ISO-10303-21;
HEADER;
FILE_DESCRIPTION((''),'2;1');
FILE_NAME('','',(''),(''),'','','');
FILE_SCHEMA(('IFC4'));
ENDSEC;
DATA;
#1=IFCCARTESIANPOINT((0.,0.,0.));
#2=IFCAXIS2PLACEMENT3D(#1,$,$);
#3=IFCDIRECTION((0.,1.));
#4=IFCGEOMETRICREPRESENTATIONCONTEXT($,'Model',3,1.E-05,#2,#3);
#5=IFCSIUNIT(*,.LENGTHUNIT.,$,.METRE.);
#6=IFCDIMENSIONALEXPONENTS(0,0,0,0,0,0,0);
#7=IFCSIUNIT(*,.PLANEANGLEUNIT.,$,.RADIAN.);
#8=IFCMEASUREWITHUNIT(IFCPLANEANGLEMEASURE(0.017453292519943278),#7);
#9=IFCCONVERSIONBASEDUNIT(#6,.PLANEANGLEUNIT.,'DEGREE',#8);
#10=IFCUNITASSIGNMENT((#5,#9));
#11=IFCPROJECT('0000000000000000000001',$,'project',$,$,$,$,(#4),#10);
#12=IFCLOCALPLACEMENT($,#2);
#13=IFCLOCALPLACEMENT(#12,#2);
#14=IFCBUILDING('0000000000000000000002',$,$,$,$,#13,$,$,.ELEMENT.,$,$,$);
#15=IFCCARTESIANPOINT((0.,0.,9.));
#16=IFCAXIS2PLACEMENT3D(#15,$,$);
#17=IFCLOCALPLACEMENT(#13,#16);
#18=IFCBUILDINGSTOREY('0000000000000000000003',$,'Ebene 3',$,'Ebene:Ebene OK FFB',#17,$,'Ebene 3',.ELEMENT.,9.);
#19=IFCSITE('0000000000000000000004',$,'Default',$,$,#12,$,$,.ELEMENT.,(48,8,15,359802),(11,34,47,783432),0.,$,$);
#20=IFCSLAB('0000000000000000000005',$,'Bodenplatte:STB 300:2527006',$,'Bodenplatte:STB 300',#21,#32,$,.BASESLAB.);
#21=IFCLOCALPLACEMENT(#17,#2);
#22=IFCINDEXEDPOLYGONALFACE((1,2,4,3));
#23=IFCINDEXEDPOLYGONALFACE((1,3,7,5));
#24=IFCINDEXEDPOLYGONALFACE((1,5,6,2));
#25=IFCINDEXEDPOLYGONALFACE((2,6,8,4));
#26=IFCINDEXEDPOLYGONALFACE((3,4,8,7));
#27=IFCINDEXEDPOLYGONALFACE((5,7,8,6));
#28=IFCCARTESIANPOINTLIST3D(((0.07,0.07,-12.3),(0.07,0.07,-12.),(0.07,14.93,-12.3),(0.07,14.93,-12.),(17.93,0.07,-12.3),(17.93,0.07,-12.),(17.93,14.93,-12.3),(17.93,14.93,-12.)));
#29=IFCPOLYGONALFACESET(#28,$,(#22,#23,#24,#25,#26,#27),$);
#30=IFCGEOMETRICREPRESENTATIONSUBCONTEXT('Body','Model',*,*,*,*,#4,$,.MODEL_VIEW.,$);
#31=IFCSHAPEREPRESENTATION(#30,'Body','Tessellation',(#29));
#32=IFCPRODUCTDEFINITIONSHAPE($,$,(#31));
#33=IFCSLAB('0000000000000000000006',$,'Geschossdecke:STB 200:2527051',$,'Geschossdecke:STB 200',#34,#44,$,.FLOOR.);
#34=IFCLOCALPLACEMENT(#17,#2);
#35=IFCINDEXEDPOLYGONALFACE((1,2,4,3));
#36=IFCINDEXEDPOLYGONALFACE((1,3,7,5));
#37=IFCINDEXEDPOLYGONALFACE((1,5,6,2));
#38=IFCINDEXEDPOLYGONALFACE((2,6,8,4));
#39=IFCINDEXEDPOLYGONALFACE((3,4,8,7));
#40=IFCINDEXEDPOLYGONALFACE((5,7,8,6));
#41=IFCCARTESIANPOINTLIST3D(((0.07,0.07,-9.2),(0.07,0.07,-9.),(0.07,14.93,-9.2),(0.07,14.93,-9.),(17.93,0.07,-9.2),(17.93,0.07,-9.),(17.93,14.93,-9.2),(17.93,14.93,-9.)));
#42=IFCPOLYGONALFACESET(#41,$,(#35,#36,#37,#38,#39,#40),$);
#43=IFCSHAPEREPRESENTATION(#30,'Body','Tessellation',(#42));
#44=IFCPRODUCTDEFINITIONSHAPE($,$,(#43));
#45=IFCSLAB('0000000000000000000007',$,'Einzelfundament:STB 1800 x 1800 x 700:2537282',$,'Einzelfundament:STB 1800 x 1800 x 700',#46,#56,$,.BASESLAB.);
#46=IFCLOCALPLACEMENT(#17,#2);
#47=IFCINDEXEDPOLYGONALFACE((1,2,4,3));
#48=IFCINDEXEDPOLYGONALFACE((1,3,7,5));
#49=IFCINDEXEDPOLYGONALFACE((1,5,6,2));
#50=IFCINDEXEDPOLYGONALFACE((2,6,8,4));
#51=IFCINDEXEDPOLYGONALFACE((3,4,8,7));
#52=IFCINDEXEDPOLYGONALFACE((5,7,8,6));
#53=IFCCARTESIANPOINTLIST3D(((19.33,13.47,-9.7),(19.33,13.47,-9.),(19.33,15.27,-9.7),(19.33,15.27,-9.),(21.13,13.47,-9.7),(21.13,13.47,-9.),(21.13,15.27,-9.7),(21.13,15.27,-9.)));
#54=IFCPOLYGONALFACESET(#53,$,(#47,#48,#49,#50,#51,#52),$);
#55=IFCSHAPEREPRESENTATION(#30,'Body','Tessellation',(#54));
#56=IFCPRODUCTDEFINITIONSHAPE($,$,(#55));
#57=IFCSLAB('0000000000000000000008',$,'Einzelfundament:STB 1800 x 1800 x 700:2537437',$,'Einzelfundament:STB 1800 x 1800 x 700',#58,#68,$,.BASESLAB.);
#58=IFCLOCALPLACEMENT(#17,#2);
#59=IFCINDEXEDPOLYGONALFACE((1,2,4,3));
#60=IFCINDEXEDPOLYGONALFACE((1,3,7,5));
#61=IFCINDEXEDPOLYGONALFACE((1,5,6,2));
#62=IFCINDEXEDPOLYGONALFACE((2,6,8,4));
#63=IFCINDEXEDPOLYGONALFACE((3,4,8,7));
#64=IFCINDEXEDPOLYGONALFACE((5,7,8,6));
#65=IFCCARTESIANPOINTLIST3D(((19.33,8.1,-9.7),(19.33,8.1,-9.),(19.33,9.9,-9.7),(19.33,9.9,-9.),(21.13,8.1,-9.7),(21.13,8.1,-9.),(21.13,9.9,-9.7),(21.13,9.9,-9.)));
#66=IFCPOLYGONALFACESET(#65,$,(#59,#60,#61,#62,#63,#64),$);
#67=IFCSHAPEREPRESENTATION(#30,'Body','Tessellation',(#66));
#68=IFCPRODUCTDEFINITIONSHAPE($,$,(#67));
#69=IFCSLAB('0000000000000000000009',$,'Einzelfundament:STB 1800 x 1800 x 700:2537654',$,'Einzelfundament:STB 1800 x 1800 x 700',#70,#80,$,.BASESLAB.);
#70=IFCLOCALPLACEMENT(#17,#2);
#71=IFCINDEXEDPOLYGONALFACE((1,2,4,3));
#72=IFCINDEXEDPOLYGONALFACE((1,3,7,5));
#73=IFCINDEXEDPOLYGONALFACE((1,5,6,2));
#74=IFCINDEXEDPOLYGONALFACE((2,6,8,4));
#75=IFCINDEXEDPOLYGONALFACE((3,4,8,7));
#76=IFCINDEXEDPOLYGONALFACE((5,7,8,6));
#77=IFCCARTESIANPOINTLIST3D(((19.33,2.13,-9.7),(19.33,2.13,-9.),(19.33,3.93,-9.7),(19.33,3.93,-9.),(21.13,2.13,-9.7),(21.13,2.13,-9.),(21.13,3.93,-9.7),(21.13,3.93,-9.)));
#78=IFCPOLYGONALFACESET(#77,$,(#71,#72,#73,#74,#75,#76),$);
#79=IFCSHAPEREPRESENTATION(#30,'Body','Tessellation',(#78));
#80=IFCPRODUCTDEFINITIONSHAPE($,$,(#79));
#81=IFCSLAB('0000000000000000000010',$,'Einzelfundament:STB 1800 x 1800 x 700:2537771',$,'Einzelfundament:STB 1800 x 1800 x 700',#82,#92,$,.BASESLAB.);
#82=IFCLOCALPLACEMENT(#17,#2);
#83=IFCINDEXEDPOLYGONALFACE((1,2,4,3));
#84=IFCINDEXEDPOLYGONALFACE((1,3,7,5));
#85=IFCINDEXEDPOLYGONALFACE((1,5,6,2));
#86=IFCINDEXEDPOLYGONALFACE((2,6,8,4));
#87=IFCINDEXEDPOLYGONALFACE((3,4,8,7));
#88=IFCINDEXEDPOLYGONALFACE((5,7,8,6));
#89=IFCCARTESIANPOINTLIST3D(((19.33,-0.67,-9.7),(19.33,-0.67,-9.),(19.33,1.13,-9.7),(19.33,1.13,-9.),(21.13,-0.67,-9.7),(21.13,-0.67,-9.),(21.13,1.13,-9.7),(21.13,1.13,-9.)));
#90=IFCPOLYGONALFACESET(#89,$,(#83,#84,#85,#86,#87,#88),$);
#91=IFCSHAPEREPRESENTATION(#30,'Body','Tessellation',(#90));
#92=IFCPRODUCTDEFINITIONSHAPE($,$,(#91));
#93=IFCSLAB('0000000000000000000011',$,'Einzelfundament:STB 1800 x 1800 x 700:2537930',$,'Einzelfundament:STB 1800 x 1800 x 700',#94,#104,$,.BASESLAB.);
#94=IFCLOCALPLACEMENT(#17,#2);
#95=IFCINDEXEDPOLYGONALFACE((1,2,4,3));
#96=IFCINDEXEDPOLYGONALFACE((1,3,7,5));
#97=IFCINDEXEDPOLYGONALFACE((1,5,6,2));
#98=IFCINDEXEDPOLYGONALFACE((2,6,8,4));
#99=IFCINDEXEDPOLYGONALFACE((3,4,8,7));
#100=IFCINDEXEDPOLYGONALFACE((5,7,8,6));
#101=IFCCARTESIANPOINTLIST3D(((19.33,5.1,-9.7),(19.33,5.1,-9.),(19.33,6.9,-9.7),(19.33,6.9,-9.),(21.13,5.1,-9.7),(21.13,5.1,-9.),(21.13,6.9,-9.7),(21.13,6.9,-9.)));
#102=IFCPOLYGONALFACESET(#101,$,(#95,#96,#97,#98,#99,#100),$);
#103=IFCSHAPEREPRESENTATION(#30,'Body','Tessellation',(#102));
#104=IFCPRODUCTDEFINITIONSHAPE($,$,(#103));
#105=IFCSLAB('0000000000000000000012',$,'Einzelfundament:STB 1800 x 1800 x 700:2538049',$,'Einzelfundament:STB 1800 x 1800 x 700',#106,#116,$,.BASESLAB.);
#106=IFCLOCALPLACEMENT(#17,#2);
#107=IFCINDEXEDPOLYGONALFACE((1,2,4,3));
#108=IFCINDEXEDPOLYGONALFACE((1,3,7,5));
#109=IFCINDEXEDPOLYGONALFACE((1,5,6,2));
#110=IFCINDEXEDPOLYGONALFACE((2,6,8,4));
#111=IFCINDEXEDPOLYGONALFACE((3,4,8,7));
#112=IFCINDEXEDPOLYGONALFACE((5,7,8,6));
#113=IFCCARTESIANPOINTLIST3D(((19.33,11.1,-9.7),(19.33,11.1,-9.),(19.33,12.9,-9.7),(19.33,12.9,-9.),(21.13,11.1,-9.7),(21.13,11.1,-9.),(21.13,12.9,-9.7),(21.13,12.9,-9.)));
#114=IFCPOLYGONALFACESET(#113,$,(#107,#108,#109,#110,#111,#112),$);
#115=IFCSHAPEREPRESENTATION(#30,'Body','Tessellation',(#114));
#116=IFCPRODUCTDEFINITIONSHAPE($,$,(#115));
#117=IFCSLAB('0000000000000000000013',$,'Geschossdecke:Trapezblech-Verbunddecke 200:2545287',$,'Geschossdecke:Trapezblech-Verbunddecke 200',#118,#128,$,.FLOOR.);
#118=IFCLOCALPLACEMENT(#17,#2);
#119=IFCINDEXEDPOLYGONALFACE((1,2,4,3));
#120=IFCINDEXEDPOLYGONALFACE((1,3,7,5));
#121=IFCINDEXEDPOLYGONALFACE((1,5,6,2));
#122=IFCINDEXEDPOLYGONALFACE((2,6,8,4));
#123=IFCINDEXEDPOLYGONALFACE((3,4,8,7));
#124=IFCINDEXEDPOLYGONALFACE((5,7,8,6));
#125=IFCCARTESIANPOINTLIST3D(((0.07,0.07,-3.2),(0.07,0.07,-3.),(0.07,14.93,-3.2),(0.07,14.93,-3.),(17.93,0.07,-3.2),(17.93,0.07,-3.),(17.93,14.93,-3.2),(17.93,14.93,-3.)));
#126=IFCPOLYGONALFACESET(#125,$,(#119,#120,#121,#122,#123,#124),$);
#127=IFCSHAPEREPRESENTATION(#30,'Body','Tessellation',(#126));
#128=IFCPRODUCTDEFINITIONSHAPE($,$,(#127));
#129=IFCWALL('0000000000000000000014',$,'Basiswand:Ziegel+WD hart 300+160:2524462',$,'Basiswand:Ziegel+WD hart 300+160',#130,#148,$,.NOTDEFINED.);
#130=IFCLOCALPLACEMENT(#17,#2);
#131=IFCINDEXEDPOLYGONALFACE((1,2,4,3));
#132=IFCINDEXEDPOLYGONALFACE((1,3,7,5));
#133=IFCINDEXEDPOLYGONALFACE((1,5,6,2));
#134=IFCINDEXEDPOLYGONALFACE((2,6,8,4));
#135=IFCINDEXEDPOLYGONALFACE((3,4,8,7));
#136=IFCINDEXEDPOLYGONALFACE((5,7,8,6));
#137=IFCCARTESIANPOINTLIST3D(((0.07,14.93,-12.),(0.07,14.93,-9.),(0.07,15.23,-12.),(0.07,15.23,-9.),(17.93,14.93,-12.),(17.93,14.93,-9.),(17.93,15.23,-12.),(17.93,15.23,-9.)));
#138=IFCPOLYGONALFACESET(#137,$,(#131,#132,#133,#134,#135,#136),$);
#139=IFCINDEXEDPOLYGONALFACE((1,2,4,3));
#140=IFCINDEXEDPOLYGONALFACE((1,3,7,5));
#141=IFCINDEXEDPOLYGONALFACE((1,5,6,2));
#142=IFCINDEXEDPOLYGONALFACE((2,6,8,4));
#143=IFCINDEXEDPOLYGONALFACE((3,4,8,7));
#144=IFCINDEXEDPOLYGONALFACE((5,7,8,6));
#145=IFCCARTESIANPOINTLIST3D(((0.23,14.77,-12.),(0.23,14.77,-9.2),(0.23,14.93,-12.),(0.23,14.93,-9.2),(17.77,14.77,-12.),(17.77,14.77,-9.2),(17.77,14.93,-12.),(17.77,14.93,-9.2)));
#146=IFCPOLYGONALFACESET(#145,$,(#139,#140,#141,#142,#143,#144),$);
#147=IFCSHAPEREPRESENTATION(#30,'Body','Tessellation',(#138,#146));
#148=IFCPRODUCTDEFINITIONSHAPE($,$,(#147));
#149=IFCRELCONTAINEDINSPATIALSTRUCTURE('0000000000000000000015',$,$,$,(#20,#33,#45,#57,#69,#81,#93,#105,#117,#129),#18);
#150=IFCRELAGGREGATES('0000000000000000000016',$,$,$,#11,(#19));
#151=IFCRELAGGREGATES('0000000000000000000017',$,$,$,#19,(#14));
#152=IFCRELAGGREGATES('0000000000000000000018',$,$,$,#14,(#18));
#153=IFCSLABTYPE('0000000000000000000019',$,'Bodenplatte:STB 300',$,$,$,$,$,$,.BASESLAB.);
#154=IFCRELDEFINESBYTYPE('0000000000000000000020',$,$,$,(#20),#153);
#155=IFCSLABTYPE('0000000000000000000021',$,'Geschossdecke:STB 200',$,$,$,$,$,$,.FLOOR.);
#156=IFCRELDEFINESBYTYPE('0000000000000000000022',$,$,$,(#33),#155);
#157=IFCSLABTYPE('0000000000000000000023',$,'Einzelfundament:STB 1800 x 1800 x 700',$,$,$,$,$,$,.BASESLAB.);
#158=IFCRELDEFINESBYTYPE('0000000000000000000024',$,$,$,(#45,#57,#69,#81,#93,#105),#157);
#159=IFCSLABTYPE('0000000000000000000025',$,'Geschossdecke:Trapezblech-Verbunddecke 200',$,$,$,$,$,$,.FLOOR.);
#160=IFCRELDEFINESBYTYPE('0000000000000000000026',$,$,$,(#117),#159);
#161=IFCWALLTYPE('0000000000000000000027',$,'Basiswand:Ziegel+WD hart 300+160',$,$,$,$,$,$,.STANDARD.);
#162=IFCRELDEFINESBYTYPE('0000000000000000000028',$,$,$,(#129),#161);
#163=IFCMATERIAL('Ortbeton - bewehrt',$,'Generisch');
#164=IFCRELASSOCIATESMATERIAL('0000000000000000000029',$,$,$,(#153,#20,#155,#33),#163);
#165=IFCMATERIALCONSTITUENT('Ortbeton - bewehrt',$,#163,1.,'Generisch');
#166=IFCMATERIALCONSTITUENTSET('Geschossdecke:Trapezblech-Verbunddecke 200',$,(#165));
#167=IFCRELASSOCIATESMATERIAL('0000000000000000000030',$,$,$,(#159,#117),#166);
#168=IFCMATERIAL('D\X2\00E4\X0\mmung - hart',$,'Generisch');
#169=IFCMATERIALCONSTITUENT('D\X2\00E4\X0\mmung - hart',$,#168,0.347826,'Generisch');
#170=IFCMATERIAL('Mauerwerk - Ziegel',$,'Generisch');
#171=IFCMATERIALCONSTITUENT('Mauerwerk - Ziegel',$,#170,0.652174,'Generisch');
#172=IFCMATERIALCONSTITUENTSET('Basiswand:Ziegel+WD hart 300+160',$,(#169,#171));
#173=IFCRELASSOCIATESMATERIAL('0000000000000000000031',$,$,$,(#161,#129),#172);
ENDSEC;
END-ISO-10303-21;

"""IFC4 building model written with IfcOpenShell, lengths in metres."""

from ifc_helpers import new_model, entity, si_unit, converted_unit, direction, frame, origin, place, context, subcontext, project, spatial, indexed_curve, outline, extrude, material, constituent, constituent_set, type_object, element, save


model = new_model("IFC4")

# Units and contexts
model_context = context("Model", 3, precision=1e-05, world=origin(), true_north=direction((0.0, 1.0)))
body_context = subcontext(model_context, "Body", "Model", "MODEL_VIEW")
ifc_project = project(units=[si_unit("LENGTHUNIT", "METRE"), converted_unit("PLANEANGLEUNIT", "DEGREE", entity("IfcPlaneAngleMeasure", 0.017453292519943278), si_unit("PLANEANGLEUNIT", "RADIAN"), dimensions=[0, 0, 0, 0, 0, 0, 0])], contexts=[model_context])

# Site, building, storey
site_placement = place(None, origin())
site = spatial("IfcSite", under=ifc_project, at=site_placement, Name="Default", CompositionType="ELEMENT", RefLatitude=(48, 8, 15, 359802), RefLongitude=(11, 34, 47, 783432), RefElevation=0.0)
building_placement = place(site_placement, origin())
building = spatial("IfcBuilding", under=site, at=building_placement, CompositionType="ELEMENT")
storey_placement = place(building_placement, frame((0.0, 0.0, 9.0)))
storey = spatial("IfcBuildingStorey", under=building, at=storey_placement, Name="Ebene 3", ObjectType="Ebene:Ebene OK FFB", LongName="Ebene 3", CompositionType="ELEMENT", Elevation=9.0)

# Slabs
ifc_material_1 = material(Name="Ortbeton - bewehrt", Category="Generisch")
slab_type_1 = type_object("IfcSlabType", Name="Bodenplatte:STB 300", PredefinedType="BASESLAB", material=ifc_material_1)
slab_1_placement = place(storey_placement, origin())
element("IfcSlab", 1, at=slab_1_placement, inside=storey, type_object=slab_type_1, material=ifc_material_1, Name="Bodenplatte:STB 300:2527006", ObjectType="Bodenplatte:STB 300", PredefinedType="BASESLAB", context=body_context, shape_type="SweptSolid", body=[
    extrude(outline(indexed_curve([(-7.43, -8.93), (7.43, -8.93), (7.43, 8.93), (-7.43, 8.93), (-7.43, -8.93)], self_intersect=False)), frame((9.0, 7.5, -12.0), z_axis=(0.0, 0.0, -1.0), x_axis=(0.0, 1.0, 0.0)), (0.0, 0.0, 1.0), 0.3),
])
slab_type_2 = type_object("IfcSlabType", Name="Geschossdecke:STB 200", PredefinedType="FLOOR", material=ifc_material_1)
slab_2_placement = place(storey_placement, origin())
element("IfcSlab", 2, at=slab_2_placement, inside=storey, type_object=slab_type_2, material=ifc_material_1, Name="Geschossdecke:STB 200:2527051", ObjectType="Geschossdecke:STB 200", PredefinedType="FLOOR", context=body_context, shape_type="SweptSolid", body=[
    extrude(outline(indexed_curve([(-7.43, -8.93), (7.43, -8.93), (7.43, 8.93), (-7.43, 8.93), (-7.43, -8.93)], self_intersect=False)), frame((9.0, 7.5, -9.0), z_axis=(0.0, 0.0, -1.0), x_axis=(0.0, 1.0, 0.0)), (0.0, 0.0, 1.0), 0.2),
])

# Slabs
slab_type_3 = type_object("IfcSlabType", Name="Einzelfundament:STB 1800 x 1800 x 700", PredefinedType="BASESLAB")
slab_3_placement = place(storey_placement, origin())
element("IfcSlab", 3, at=slab_3_placement, inside=storey, type_object=slab_type_3, Name="Einzelfundament:STB 1800 x 1800 x 700:2537282", ObjectType="Einzelfundament:STB 1800 x 1800 x 700", PredefinedType="BASESLAB", context=body_context, shape_type="SweptSolid", body=[
    extrude(outline(indexed_curve([(-0.9, -0.9), (0.9, -0.9), (0.9, 0.9), (-0.9, 0.9), (-0.9, -0.9)], self_intersect=False)), frame((20.23, 14.37, -9.7), z_axis=(0.0, 0.0, 1.0), x_axis=(-1.0, 0.0, 0.0)), (0.0, 0.0, 1.0), 0.7),
])
slab_4_placement = place(storey_placement, origin())
element("IfcSlab", 4, at=slab_4_placement, inside=storey, type_object=slab_type_3, Name="Einzelfundament:STB 1800 x 1800 x 700:2537437", ObjectType="Einzelfundament:STB 1800 x 1800 x 700", PredefinedType="BASESLAB", context=body_context, shape_type="SweptSolid", body=[
    extrude(outline(indexed_curve([(-0.9, -0.9), (0.9, -0.9), (0.9, 0.9), (-0.9, 0.9), (-0.9, -0.9)], self_intersect=False)), frame((20.23, 9.0, -9.7), z_axis=(0.0, 0.0, 1.0), x_axis=(-1.0, 0.0, 0.0)), (0.0, 0.0, 1.0), 0.7),
])
slab_5_placement = place(storey_placement, origin())
element("IfcSlab", 5, at=slab_5_placement, inside=storey, type_object=slab_type_3, Name="Einzelfundament:STB 1800 x 1800 x 700:2537654", ObjectType="Einzelfundament:STB 1800 x 1800 x 700", PredefinedType="BASESLAB", context=body_context, shape_type="SweptSolid", body=[
    extrude(outline(indexed_curve([(-0.9, -0.9), (0.9, -0.9), (0.9, 0.9), (-0.9, 0.9), (-0.9, -0.9)], self_intersect=False)), frame((20.23, 3.03, -9.7), z_axis=(0.0, 0.0, 1.0), x_axis=(-1.0, 0.0, 0.0)), (0.0, 0.0, 1.0), 0.7),
])
slab_6_placement = place(storey_placement, origin())
element("IfcSlab", 6, at=slab_6_placement, inside=storey, type_object=slab_type_3, Name="Einzelfundament:STB 1800 x 1800 x 700:2537771", ObjectType="Einzelfundament:STB 1800 x 1800 x 700", PredefinedType="BASESLAB", context=body_context, shape_type="SweptSolid", body=[
    extrude(outline(indexed_curve([(-0.9, -0.9), (0.9, -0.9), (0.9, 0.9), (-0.9, 0.9), (-0.9, -0.9)], self_intersect=False)), frame((20.23, 0.23, -9.7), z_axis=(0.0, 0.0, 1.0), x_axis=(-1.0, 0.0, 0.0)), (0.0, 0.0, 1.0), 0.7),
])
slab_7_placement = place(storey_placement, origin())
element("IfcSlab", 7, at=slab_7_placement, inside=storey, type_object=slab_type_3, Name="Einzelfundament:STB 1800 x 1800 x 700:2537930", ObjectType="Einzelfundament:STB 1800 x 1800 x 700", PredefinedType="BASESLAB", context=body_context, shape_type="SweptSolid", body=[
    extrude(outline(indexed_curve([(-0.9, -0.9), (0.9, -0.9), (0.9, 0.9), (-0.9, 0.9), (-0.9, -0.9)], self_intersect=False)), frame((20.23, 6.0, -9.7), z_axis=(0.0, 0.0, 1.0), x_axis=(-1.0, 0.0, 0.0)), (0.0, 0.0, 1.0), 0.7),
])
slab_8_placement = place(storey_placement, origin())
element("IfcSlab", 8, at=slab_8_placement, inside=storey, type_object=slab_type_3, Name="Einzelfundament:STB 1800 x 1800 x 700:2538049", ObjectType="Einzelfundament:STB 1800 x 1800 x 700", PredefinedType="BASESLAB", context=body_context, shape_type="SweptSolid", body=[
    extrude(outline(indexed_curve([(-0.9, -0.9), (0.9, -0.9), (0.9, 0.9), (-0.9, 0.9), (-0.9, -0.9)], self_intersect=False)), frame((20.23, 12.0, -9.7), z_axis=(0.0, 0.0, 1.0), x_axis=(-1.0, 0.0, 0.0)), (0.0, 0.0, 1.0), 0.7),
])
ifc_constituent_1 = constituent(ifc_material_1, Name="Ortbeton - bewehrt", Category="Generisch", fraction=1.0)
ifc_constituent_set_1 = constituent_set(constituents=[ifc_constituent_1], Name="Geschossdecke:Trapezblech-Verbunddecke 200")
slab_type_4 = type_object("IfcSlabType", Name="Geschossdecke:Trapezblech-Verbunddecke 200", PredefinedType="FLOOR", material=ifc_constituent_set_1)
slab_9_placement = place(storey_placement, origin())
element("IfcSlab", 9, at=slab_9_placement, inside=storey, type_object=slab_type_4, material=ifc_constituent_set_1, Name="Geschossdecke:Trapezblech-Verbunddecke 200:2545287", ObjectType="Geschossdecke:Trapezblech-Verbunddecke 200", PredefinedType="FLOOR", context=body_context, shape_type="SweptSolid", body=[
    extrude(outline(indexed_curve([(-7.43, -8.93), (7.43, -8.93), (7.43, 8.93), (-7.43, 8.93), (-7.43, -8.93)], self_intersect=False)), frame((9.0, 7.5, -3.0), z_axis=(0.0, 0.0, -1.0), x_axis=(0.0, 1.0, 0.0)), (0.0, 0.0, 1.0), 0.2),
])

# Wall
ifc_material_2 = material(Name="Dämmung - hart", Category="Generisch")
ifc_constituent_2 = constituent(ifc_material_2, Name="Dämmung - hart", Category="Generisch", fraction=0.347826)
ifc_material_3 = material(Name="Mauerwerk - Ziegel", Category="Generisch")
ifc_constituent_3 = constituent(ifc_material_3, Name="Mauerwerk - Ziegel", Category="Generisch", fraction=0.652174)
ifc_constituent_set_2 = constituent_set(constituents=[ifc_constituent_2, ifc_constituent_3], Name="Basiswand:Ziegel+WD hart 300+160")
wall_type_1 = type_object("IfcWallType", Name="Basiswand:Ziegel+WD hart 300+160", PredefinedType="STANDARD", material=ifc_constituent_set_2)
wall_1_placement = place(storey_placement, frame((17.77, 15.0, -12.0), z_axis=(0.0, 0.0, 1.0), x_axis=(-1.0, 0.0, 0.0)))
element("IfcWall", 10, at=wall_1_placement, inside=storey, type_object=wall_type_1, material=ifc_constituent_set_2, Name="Basiswand:Ziegel+WD hart 300+160:2524462", ObjectType="Basiswand:Ziegel+WD hart 300+160", PredefinedType="NOTDEFINED", context=body_context, shape_type="SweptSolid", body=[
    extrude(outline(indexed_curve([(-0.15, -8.93), (0.15, -8.93), (0.15, 8.93), (-0.15, 8.93), (-0.15, -8.93)], self_intersect=False)), frame((8.77, -0.08, 0.0), z_axis=(0.0, 0.0, 1.0), x_axis=(0.0, 1.0, 0.0)), (0.0, 0.0, 1.0), 3.0),
    extrude(outline(indexed_curve([(-0.08, -8.77), (0.08, -8.77), (0.08, 8.77), (-0.08, 8.77), (-0.08, -8.77)], self_intersect=False)), frame((8.77, 0.15, 0.0), z_axis=(0.0, 0.0, 1.0), x_axis=(0.0, -1.0, 0.0)), (0.0, 0.0, 1.0), 2.8),
])

save(model, "model.ifc")
